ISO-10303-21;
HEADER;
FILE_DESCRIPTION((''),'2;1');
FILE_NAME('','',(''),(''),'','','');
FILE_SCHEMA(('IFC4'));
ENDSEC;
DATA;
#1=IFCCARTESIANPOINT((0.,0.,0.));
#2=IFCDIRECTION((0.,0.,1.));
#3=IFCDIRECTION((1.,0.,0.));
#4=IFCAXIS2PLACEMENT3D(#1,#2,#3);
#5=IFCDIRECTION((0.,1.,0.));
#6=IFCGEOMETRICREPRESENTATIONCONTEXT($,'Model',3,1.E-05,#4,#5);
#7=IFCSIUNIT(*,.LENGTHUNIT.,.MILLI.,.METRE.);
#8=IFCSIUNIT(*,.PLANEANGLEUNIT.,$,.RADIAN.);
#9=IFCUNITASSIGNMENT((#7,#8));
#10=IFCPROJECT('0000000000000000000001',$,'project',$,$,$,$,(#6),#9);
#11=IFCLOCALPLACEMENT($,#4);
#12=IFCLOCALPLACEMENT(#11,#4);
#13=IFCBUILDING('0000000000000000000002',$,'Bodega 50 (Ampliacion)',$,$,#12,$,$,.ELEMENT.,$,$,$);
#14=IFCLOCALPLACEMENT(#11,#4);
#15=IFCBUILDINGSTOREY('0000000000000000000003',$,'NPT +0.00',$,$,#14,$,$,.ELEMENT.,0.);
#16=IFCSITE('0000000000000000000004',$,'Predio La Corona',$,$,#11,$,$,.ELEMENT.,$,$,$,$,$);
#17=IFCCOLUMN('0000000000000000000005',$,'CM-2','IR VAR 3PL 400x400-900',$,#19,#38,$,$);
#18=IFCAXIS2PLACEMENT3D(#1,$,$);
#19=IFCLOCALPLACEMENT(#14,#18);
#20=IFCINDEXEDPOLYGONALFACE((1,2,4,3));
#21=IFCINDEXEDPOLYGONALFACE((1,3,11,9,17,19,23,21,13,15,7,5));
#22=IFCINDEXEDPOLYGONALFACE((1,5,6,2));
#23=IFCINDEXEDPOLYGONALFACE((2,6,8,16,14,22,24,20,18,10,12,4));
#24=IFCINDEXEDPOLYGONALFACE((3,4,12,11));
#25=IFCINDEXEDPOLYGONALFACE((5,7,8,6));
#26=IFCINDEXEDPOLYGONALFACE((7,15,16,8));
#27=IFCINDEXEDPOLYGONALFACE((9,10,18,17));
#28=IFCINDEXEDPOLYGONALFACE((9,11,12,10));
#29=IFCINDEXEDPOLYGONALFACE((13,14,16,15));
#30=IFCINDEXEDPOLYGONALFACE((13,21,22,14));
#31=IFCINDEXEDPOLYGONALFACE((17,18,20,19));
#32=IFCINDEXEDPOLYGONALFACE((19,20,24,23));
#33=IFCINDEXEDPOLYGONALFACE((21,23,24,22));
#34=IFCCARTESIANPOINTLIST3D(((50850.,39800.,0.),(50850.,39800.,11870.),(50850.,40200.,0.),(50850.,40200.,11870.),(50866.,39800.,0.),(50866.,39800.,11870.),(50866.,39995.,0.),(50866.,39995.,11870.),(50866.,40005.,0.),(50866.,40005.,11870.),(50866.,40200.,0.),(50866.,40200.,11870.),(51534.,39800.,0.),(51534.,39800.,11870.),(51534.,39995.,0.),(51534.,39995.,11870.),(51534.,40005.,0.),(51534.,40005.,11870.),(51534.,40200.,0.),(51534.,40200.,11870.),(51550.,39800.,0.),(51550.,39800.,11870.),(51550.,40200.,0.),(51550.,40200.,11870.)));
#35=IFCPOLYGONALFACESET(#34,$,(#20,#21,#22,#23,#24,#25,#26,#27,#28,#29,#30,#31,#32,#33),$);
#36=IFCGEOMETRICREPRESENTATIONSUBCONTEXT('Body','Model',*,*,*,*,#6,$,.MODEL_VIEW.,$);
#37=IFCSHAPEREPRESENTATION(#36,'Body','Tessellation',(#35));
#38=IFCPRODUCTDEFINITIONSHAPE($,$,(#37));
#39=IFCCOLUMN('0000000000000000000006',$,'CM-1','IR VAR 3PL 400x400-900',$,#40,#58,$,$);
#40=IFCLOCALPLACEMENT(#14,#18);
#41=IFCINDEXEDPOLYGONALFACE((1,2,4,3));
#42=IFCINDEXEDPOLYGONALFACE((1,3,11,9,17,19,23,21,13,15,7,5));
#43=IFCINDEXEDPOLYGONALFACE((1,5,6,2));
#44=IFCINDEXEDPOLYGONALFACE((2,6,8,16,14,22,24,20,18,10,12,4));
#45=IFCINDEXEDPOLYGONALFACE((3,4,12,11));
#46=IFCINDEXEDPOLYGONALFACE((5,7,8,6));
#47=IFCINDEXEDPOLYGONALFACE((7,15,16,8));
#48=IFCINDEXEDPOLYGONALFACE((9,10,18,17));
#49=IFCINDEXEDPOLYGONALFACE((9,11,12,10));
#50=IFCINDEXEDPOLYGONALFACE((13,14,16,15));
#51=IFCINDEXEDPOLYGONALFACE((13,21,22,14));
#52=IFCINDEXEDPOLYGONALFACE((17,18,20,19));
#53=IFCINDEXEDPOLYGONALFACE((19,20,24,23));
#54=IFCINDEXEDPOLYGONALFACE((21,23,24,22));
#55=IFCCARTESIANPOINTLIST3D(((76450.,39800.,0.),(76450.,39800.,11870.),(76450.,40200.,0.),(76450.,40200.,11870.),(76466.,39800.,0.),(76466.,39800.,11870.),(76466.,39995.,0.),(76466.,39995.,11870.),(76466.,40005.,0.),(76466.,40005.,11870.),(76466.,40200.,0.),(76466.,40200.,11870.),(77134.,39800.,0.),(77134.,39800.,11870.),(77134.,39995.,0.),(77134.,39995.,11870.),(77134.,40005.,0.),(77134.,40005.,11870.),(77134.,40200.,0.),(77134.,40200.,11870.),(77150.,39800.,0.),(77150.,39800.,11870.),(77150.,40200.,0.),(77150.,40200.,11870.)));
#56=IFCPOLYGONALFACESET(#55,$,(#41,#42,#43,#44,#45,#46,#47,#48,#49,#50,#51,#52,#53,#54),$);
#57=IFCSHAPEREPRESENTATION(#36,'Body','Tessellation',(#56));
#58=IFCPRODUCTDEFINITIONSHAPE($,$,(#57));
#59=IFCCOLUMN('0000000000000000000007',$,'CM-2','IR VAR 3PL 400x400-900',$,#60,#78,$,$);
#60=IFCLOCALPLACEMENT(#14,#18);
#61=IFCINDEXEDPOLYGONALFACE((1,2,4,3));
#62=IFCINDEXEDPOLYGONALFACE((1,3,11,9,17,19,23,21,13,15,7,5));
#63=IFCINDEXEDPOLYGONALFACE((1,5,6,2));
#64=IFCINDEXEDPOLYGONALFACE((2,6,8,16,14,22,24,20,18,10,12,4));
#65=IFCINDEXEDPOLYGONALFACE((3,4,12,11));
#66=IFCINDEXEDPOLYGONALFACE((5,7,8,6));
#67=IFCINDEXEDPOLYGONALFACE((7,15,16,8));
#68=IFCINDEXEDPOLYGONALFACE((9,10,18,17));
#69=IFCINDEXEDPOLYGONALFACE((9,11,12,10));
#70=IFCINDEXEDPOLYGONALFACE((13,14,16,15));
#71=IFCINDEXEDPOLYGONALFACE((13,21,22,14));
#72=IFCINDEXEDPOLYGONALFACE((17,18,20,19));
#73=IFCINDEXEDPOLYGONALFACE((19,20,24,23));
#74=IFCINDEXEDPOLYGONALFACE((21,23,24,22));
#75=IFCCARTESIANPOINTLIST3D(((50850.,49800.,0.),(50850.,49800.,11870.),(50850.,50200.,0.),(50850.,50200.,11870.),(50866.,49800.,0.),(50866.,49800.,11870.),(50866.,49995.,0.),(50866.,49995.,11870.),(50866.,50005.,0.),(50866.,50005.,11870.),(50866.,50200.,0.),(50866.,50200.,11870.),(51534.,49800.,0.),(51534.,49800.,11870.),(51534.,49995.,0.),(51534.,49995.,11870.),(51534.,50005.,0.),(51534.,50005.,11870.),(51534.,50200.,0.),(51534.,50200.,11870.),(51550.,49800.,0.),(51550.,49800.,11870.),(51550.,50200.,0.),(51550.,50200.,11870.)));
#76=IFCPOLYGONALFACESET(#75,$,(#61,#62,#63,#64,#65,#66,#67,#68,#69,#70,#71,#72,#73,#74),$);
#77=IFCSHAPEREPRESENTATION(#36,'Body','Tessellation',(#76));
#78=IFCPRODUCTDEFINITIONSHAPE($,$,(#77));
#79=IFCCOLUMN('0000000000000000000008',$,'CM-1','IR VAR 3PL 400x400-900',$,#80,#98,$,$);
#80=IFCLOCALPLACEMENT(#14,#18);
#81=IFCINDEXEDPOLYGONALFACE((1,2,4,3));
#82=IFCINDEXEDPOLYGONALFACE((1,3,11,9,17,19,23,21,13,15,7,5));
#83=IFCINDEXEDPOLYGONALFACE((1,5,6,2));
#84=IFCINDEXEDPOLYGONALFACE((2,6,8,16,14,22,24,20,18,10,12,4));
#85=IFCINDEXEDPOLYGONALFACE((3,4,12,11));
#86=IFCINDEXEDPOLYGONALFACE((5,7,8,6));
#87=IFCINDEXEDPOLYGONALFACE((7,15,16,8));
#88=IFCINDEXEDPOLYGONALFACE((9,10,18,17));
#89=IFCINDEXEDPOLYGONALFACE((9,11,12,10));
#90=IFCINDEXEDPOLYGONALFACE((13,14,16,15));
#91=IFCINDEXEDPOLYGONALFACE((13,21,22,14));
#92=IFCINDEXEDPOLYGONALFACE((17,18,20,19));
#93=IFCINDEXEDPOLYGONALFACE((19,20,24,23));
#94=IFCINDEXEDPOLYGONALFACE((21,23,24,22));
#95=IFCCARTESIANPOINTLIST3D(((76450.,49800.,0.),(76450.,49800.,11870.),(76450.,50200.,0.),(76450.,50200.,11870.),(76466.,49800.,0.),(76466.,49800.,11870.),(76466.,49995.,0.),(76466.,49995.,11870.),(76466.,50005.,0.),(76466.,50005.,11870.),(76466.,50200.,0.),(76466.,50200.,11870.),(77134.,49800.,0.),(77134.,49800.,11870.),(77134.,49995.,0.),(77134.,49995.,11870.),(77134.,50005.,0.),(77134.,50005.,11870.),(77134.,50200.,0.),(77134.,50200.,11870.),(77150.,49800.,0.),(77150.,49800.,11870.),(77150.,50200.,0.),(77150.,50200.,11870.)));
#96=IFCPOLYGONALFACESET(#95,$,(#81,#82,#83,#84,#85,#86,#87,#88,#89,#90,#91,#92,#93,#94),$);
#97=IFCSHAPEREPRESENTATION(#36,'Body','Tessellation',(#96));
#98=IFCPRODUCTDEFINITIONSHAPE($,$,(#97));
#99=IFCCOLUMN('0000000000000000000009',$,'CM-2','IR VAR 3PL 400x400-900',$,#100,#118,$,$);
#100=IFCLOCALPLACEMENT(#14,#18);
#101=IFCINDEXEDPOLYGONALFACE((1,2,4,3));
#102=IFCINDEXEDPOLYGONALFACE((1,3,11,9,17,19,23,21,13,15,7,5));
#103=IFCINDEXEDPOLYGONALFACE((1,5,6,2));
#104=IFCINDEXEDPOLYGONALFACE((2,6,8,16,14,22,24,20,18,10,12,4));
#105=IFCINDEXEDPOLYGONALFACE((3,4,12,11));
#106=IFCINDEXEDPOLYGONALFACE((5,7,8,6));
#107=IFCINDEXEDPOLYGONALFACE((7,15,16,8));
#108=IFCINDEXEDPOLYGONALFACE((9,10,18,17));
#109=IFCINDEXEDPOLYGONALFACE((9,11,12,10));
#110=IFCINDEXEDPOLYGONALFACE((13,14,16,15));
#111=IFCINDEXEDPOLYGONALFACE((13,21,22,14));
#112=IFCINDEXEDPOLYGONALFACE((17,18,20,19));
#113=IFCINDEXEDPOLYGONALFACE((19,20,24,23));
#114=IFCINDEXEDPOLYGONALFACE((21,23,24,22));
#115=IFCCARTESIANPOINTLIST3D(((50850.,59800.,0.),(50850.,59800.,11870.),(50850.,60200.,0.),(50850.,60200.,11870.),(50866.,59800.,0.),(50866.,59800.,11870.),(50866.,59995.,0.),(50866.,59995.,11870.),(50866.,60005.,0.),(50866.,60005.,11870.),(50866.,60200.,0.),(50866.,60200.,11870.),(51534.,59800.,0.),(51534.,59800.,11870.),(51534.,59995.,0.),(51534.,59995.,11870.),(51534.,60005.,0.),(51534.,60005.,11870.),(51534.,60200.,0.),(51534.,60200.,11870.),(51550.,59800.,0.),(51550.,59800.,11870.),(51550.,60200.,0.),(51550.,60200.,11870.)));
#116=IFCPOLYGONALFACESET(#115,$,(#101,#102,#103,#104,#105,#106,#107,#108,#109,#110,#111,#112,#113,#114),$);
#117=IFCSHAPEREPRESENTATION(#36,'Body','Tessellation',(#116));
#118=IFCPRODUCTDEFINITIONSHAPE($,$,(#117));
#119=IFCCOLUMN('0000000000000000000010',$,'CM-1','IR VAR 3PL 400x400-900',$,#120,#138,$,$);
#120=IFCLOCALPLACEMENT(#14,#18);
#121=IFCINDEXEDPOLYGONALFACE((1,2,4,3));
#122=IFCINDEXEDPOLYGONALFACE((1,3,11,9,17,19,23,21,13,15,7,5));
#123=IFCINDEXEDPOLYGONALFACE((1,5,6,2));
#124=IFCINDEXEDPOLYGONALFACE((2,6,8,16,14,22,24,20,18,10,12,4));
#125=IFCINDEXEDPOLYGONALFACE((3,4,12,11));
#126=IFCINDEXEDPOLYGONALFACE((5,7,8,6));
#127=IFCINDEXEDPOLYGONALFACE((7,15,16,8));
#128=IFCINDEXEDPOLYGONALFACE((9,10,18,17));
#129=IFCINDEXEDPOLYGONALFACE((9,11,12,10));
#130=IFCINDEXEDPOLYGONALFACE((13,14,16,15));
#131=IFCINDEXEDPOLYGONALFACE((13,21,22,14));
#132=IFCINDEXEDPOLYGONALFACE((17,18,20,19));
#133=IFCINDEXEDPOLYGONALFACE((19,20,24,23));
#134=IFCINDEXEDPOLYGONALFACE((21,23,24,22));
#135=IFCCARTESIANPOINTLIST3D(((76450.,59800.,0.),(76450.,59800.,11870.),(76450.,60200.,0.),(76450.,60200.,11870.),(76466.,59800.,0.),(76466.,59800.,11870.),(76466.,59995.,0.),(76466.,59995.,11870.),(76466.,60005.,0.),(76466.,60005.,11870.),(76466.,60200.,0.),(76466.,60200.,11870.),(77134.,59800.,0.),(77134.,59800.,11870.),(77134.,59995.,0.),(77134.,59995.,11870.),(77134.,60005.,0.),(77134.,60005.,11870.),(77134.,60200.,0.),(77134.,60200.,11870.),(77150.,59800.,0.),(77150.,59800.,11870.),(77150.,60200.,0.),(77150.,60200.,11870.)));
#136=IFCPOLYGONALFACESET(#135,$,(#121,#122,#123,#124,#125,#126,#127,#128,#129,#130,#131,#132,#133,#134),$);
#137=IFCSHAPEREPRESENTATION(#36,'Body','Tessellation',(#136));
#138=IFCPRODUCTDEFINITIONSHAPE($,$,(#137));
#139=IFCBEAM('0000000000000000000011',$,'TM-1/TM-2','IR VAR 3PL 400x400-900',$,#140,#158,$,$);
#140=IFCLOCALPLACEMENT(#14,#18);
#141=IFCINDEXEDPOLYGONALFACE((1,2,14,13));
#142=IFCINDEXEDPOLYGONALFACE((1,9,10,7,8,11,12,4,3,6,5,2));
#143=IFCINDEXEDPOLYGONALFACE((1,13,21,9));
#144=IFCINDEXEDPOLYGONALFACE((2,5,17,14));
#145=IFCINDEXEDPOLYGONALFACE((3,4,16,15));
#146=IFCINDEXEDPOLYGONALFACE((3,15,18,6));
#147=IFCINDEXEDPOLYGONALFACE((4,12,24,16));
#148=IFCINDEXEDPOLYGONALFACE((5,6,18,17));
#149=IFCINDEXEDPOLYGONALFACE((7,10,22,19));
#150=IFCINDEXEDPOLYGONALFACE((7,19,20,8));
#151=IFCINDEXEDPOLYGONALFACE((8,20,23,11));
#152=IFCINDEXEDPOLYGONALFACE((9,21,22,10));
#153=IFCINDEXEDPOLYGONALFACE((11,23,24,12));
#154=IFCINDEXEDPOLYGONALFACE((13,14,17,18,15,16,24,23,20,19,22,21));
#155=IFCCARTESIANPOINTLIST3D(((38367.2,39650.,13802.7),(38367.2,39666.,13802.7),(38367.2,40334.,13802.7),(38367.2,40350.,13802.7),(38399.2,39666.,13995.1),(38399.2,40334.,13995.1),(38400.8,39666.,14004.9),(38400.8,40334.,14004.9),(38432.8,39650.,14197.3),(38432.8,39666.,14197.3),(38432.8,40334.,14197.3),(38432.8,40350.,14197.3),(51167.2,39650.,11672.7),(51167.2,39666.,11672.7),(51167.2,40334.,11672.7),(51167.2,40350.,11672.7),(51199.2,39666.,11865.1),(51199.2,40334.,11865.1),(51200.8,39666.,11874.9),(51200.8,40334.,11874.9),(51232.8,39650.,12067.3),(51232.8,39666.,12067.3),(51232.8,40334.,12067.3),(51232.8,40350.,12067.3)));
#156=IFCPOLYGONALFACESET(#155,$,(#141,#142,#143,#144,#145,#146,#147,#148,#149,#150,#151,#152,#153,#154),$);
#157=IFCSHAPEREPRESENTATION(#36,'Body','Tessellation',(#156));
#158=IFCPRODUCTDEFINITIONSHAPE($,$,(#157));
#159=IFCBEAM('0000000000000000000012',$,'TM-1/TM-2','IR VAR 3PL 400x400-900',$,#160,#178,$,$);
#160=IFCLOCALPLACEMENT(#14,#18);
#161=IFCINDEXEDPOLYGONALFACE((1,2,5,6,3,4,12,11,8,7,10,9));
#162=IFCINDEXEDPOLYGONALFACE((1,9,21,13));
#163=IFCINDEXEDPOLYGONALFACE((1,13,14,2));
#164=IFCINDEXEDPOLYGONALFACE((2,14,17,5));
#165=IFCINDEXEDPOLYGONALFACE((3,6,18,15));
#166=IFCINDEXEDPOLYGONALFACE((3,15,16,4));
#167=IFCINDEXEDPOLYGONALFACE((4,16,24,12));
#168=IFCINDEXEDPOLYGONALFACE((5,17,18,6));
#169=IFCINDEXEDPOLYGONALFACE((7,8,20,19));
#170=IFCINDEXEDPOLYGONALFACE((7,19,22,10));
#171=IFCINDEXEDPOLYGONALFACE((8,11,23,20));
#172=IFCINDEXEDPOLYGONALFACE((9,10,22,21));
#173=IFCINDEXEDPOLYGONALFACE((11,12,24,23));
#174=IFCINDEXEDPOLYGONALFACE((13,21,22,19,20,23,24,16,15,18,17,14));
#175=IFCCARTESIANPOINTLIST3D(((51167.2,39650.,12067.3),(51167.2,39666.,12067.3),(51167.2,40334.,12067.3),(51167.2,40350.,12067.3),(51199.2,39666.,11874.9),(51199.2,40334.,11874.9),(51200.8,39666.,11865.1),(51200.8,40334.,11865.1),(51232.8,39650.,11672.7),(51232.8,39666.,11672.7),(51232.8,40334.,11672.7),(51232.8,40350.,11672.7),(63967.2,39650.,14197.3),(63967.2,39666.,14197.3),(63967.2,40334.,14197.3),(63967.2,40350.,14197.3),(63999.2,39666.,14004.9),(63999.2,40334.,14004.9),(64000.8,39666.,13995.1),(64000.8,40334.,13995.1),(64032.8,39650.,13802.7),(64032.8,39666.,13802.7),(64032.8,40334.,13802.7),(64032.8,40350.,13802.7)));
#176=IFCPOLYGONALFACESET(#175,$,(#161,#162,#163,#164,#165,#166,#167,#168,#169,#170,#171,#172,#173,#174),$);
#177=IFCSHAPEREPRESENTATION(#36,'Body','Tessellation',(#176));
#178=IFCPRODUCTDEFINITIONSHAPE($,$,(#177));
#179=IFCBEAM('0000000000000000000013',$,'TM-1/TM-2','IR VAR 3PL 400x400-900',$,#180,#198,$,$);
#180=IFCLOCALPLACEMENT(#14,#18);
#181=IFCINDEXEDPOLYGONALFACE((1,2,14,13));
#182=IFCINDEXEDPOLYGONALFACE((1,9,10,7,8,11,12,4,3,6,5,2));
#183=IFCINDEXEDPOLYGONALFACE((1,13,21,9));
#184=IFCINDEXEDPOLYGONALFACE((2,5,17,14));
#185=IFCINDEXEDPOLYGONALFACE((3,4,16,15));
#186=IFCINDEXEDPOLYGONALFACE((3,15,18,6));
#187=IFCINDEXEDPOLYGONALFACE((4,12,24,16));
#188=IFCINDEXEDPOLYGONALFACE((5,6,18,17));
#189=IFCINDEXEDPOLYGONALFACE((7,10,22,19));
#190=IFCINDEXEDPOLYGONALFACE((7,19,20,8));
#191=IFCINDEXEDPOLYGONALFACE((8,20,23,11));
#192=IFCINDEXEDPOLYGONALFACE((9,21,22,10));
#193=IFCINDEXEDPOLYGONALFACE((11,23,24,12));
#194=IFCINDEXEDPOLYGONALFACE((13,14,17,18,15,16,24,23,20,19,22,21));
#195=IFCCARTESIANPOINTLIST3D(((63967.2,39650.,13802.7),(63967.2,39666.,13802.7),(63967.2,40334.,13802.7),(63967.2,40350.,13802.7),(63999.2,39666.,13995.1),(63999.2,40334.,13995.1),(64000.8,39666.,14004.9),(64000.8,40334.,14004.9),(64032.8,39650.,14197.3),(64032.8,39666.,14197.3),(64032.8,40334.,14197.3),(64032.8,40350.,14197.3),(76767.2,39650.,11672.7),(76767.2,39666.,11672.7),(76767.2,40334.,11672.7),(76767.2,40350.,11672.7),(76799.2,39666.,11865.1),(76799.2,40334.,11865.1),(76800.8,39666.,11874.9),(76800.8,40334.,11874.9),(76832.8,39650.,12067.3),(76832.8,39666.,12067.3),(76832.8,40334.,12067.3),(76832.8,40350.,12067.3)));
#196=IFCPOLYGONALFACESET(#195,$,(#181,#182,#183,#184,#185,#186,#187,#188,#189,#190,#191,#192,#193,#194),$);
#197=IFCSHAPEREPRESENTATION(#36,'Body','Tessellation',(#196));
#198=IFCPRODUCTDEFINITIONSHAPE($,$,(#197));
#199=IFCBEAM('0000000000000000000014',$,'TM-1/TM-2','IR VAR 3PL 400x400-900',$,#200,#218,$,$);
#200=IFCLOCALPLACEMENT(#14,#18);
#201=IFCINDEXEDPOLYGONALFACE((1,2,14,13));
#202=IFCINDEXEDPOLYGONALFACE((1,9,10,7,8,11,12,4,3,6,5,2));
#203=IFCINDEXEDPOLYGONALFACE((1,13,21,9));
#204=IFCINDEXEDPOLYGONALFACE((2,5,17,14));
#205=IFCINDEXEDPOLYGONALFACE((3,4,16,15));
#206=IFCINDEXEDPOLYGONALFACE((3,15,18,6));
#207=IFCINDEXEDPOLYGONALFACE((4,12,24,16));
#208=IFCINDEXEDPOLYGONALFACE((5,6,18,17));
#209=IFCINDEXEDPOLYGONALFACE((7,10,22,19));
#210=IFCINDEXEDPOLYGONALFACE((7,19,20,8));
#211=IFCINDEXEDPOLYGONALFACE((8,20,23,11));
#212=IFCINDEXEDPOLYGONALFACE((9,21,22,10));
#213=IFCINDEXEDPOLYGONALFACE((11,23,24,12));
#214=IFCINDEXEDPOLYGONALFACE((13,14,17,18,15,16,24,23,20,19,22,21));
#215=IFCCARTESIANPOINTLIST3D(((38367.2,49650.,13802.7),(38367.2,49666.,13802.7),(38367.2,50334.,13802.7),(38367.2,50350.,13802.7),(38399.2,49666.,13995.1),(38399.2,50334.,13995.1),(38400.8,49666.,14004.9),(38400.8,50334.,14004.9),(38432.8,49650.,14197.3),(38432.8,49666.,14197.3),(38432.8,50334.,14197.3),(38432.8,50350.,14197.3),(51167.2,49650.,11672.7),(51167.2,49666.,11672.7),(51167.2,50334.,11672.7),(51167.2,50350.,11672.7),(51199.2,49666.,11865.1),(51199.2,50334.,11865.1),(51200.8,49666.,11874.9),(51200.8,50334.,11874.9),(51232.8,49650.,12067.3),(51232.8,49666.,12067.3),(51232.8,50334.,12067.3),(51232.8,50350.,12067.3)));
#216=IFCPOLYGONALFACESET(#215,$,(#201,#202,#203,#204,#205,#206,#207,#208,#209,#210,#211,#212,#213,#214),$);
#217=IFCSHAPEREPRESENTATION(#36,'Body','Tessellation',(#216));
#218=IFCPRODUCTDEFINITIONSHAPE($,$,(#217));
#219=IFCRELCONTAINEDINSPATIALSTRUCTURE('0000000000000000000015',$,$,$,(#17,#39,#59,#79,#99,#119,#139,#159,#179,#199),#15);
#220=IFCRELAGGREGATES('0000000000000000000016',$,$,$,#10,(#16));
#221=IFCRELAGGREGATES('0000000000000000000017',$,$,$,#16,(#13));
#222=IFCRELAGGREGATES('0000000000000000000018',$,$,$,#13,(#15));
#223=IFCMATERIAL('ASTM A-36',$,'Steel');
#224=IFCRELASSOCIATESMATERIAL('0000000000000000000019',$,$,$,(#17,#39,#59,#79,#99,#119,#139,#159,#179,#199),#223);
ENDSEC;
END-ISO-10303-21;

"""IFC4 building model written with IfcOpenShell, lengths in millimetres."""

from ifc_helpers import new_model, si_unit, direction, frame, origin_with_axes, origin_2d, place, context, subcontext, project, spatial, i_section, extrude, material, element, save


model = new_model("IFC4")

# Units and contexts
model_context = context("Model", 3, precision=1e-05, world=origin_with_axes(), true_north=direction((0.0, 1.0, 0.0)))
body_context = subcontext(model_context, "Body", "Model", "MODEL_VIEW")
ifc_project = project(units=[si_unit("LENGTHUNIT", "METRE", prefix="MILLI"), si_unit("PLANEANGLEUNIT", "RADIAN")], contexts=[model_context])

# Site, building, storey
site_placement = place(None, origin_with_axes())
site = spatial("IfcSite", under=ifc_project, at=site_placement, Name="Predio La Corona", CompositionType="ELEMENT")
building_placement = place(site_placement, origin_with_axes())
building = spatial("IfcBuilding", under=site, at=building_placement, Name="Bodega 50 (Ampliacion)", CompositionType="ELEMENT")
storey_placement = place(site_placement, origin_with_axes())
storey = spatial("IfcBuildingStorey", under=building, at=storey_placement, Name="NPT +0.00", CompositionType="ELEMENT", Elevation=0.0)

# Columns
ifc_material = material(Name="ASTM A-36", Category="Steel")
for number, where, z_axis, x_axis, name in (
    (1, (51200.0, 40000.0, 0.0), (0.0, 0.0, 1.0), (0.0, -1.0, 0.0), "CM-2"),
    (2, (76800.0, 40000.0, 0.0), (0.0, 0.0, 1.0), (0.0, -1.0, 0.0), "CM-1"),
    (3, (51200.0, 50000.0, 0.0), (0.0, 0.0, 1.0), (0.0, -1.0, 0.0), "CM-2"),
    (4, (76800.0, 50000.0, 0.0), (0.0, 0.0, 1.0), (0.0, -1.0, 0.0), "CM-1"),
    (5, (51200.0, 60000.0, 0.0), (0.0, 0.0, 1.0), (0.0, -1.0, 0.0), "CM-2"),
    (6, (76800.0, 60000.0, 0.0), (0.0, 0.0, 1.0), (0.0, -1.0, 0.0), "CM-1"),
):
    element("IfcColumn", number, at=place(storey_placement, frame(where, z_axis=z_axis, x_axis=x_axis)), inside=storey, material=ifc_material, Name=name, Description="IR VAR 3PL 400x400-900", context=body_context, shape_type="SweptSolid", body=[
        extrude(i_section(OverallWidth=400.0, OverallDepth=700.0, WebThickness=10.0, FlangeThickness=16.0, at=origin_2d()), origin_with_axes(), (0.0, 0.0, 1.0), 11870.0),
    ])

# Beams
for number, where, z_axis, x_axis, name in (
    (7, (38400.0, 40000.0, 14000.0), (0.986436, 0.0, -0.164149), (-0.164149, 0.0, -0.986436), "TM-1/TM-2"),
    (8, (51200.0, 40000.0, 11870.0), (0.986436, 0.0, 0.164149), (0.164149, 0.0, -0.986436), "TM-1/TM-2"),
    (9, (64000.0, 40000.0, 14000.0), (0.986436, 0.0, -0.164149), (-0.164149, 0.0, -0.986436), "TM-1/TM-2"),
    (10, (38400.0, 50000.0, 14000.0), (0.986436, 0.0, -0.164149), (-0.164149, 0.0, -0.986436), "TM-1/TM-2"),
):
    element("IfcBeam", number, at=place(storey_placement, frame(where, z_axis=z_axis, x_axis=x_axis)), inside=storey, material=ifc_material, Name=name, Description="IR VAR 3PL 400x400-900", context=body_context, shape_type="SweptSolid", body=[
        extrude(i_section(OverallWidth=400.0, OverallDepth=700.0, WebThickness=10.0, FlangeThickness=16.0, at=origin_2d()), origin_with_axes(), (0.0, 0.0, 1.0), 12976.0),
    ])

save(model, "model.ifc")
